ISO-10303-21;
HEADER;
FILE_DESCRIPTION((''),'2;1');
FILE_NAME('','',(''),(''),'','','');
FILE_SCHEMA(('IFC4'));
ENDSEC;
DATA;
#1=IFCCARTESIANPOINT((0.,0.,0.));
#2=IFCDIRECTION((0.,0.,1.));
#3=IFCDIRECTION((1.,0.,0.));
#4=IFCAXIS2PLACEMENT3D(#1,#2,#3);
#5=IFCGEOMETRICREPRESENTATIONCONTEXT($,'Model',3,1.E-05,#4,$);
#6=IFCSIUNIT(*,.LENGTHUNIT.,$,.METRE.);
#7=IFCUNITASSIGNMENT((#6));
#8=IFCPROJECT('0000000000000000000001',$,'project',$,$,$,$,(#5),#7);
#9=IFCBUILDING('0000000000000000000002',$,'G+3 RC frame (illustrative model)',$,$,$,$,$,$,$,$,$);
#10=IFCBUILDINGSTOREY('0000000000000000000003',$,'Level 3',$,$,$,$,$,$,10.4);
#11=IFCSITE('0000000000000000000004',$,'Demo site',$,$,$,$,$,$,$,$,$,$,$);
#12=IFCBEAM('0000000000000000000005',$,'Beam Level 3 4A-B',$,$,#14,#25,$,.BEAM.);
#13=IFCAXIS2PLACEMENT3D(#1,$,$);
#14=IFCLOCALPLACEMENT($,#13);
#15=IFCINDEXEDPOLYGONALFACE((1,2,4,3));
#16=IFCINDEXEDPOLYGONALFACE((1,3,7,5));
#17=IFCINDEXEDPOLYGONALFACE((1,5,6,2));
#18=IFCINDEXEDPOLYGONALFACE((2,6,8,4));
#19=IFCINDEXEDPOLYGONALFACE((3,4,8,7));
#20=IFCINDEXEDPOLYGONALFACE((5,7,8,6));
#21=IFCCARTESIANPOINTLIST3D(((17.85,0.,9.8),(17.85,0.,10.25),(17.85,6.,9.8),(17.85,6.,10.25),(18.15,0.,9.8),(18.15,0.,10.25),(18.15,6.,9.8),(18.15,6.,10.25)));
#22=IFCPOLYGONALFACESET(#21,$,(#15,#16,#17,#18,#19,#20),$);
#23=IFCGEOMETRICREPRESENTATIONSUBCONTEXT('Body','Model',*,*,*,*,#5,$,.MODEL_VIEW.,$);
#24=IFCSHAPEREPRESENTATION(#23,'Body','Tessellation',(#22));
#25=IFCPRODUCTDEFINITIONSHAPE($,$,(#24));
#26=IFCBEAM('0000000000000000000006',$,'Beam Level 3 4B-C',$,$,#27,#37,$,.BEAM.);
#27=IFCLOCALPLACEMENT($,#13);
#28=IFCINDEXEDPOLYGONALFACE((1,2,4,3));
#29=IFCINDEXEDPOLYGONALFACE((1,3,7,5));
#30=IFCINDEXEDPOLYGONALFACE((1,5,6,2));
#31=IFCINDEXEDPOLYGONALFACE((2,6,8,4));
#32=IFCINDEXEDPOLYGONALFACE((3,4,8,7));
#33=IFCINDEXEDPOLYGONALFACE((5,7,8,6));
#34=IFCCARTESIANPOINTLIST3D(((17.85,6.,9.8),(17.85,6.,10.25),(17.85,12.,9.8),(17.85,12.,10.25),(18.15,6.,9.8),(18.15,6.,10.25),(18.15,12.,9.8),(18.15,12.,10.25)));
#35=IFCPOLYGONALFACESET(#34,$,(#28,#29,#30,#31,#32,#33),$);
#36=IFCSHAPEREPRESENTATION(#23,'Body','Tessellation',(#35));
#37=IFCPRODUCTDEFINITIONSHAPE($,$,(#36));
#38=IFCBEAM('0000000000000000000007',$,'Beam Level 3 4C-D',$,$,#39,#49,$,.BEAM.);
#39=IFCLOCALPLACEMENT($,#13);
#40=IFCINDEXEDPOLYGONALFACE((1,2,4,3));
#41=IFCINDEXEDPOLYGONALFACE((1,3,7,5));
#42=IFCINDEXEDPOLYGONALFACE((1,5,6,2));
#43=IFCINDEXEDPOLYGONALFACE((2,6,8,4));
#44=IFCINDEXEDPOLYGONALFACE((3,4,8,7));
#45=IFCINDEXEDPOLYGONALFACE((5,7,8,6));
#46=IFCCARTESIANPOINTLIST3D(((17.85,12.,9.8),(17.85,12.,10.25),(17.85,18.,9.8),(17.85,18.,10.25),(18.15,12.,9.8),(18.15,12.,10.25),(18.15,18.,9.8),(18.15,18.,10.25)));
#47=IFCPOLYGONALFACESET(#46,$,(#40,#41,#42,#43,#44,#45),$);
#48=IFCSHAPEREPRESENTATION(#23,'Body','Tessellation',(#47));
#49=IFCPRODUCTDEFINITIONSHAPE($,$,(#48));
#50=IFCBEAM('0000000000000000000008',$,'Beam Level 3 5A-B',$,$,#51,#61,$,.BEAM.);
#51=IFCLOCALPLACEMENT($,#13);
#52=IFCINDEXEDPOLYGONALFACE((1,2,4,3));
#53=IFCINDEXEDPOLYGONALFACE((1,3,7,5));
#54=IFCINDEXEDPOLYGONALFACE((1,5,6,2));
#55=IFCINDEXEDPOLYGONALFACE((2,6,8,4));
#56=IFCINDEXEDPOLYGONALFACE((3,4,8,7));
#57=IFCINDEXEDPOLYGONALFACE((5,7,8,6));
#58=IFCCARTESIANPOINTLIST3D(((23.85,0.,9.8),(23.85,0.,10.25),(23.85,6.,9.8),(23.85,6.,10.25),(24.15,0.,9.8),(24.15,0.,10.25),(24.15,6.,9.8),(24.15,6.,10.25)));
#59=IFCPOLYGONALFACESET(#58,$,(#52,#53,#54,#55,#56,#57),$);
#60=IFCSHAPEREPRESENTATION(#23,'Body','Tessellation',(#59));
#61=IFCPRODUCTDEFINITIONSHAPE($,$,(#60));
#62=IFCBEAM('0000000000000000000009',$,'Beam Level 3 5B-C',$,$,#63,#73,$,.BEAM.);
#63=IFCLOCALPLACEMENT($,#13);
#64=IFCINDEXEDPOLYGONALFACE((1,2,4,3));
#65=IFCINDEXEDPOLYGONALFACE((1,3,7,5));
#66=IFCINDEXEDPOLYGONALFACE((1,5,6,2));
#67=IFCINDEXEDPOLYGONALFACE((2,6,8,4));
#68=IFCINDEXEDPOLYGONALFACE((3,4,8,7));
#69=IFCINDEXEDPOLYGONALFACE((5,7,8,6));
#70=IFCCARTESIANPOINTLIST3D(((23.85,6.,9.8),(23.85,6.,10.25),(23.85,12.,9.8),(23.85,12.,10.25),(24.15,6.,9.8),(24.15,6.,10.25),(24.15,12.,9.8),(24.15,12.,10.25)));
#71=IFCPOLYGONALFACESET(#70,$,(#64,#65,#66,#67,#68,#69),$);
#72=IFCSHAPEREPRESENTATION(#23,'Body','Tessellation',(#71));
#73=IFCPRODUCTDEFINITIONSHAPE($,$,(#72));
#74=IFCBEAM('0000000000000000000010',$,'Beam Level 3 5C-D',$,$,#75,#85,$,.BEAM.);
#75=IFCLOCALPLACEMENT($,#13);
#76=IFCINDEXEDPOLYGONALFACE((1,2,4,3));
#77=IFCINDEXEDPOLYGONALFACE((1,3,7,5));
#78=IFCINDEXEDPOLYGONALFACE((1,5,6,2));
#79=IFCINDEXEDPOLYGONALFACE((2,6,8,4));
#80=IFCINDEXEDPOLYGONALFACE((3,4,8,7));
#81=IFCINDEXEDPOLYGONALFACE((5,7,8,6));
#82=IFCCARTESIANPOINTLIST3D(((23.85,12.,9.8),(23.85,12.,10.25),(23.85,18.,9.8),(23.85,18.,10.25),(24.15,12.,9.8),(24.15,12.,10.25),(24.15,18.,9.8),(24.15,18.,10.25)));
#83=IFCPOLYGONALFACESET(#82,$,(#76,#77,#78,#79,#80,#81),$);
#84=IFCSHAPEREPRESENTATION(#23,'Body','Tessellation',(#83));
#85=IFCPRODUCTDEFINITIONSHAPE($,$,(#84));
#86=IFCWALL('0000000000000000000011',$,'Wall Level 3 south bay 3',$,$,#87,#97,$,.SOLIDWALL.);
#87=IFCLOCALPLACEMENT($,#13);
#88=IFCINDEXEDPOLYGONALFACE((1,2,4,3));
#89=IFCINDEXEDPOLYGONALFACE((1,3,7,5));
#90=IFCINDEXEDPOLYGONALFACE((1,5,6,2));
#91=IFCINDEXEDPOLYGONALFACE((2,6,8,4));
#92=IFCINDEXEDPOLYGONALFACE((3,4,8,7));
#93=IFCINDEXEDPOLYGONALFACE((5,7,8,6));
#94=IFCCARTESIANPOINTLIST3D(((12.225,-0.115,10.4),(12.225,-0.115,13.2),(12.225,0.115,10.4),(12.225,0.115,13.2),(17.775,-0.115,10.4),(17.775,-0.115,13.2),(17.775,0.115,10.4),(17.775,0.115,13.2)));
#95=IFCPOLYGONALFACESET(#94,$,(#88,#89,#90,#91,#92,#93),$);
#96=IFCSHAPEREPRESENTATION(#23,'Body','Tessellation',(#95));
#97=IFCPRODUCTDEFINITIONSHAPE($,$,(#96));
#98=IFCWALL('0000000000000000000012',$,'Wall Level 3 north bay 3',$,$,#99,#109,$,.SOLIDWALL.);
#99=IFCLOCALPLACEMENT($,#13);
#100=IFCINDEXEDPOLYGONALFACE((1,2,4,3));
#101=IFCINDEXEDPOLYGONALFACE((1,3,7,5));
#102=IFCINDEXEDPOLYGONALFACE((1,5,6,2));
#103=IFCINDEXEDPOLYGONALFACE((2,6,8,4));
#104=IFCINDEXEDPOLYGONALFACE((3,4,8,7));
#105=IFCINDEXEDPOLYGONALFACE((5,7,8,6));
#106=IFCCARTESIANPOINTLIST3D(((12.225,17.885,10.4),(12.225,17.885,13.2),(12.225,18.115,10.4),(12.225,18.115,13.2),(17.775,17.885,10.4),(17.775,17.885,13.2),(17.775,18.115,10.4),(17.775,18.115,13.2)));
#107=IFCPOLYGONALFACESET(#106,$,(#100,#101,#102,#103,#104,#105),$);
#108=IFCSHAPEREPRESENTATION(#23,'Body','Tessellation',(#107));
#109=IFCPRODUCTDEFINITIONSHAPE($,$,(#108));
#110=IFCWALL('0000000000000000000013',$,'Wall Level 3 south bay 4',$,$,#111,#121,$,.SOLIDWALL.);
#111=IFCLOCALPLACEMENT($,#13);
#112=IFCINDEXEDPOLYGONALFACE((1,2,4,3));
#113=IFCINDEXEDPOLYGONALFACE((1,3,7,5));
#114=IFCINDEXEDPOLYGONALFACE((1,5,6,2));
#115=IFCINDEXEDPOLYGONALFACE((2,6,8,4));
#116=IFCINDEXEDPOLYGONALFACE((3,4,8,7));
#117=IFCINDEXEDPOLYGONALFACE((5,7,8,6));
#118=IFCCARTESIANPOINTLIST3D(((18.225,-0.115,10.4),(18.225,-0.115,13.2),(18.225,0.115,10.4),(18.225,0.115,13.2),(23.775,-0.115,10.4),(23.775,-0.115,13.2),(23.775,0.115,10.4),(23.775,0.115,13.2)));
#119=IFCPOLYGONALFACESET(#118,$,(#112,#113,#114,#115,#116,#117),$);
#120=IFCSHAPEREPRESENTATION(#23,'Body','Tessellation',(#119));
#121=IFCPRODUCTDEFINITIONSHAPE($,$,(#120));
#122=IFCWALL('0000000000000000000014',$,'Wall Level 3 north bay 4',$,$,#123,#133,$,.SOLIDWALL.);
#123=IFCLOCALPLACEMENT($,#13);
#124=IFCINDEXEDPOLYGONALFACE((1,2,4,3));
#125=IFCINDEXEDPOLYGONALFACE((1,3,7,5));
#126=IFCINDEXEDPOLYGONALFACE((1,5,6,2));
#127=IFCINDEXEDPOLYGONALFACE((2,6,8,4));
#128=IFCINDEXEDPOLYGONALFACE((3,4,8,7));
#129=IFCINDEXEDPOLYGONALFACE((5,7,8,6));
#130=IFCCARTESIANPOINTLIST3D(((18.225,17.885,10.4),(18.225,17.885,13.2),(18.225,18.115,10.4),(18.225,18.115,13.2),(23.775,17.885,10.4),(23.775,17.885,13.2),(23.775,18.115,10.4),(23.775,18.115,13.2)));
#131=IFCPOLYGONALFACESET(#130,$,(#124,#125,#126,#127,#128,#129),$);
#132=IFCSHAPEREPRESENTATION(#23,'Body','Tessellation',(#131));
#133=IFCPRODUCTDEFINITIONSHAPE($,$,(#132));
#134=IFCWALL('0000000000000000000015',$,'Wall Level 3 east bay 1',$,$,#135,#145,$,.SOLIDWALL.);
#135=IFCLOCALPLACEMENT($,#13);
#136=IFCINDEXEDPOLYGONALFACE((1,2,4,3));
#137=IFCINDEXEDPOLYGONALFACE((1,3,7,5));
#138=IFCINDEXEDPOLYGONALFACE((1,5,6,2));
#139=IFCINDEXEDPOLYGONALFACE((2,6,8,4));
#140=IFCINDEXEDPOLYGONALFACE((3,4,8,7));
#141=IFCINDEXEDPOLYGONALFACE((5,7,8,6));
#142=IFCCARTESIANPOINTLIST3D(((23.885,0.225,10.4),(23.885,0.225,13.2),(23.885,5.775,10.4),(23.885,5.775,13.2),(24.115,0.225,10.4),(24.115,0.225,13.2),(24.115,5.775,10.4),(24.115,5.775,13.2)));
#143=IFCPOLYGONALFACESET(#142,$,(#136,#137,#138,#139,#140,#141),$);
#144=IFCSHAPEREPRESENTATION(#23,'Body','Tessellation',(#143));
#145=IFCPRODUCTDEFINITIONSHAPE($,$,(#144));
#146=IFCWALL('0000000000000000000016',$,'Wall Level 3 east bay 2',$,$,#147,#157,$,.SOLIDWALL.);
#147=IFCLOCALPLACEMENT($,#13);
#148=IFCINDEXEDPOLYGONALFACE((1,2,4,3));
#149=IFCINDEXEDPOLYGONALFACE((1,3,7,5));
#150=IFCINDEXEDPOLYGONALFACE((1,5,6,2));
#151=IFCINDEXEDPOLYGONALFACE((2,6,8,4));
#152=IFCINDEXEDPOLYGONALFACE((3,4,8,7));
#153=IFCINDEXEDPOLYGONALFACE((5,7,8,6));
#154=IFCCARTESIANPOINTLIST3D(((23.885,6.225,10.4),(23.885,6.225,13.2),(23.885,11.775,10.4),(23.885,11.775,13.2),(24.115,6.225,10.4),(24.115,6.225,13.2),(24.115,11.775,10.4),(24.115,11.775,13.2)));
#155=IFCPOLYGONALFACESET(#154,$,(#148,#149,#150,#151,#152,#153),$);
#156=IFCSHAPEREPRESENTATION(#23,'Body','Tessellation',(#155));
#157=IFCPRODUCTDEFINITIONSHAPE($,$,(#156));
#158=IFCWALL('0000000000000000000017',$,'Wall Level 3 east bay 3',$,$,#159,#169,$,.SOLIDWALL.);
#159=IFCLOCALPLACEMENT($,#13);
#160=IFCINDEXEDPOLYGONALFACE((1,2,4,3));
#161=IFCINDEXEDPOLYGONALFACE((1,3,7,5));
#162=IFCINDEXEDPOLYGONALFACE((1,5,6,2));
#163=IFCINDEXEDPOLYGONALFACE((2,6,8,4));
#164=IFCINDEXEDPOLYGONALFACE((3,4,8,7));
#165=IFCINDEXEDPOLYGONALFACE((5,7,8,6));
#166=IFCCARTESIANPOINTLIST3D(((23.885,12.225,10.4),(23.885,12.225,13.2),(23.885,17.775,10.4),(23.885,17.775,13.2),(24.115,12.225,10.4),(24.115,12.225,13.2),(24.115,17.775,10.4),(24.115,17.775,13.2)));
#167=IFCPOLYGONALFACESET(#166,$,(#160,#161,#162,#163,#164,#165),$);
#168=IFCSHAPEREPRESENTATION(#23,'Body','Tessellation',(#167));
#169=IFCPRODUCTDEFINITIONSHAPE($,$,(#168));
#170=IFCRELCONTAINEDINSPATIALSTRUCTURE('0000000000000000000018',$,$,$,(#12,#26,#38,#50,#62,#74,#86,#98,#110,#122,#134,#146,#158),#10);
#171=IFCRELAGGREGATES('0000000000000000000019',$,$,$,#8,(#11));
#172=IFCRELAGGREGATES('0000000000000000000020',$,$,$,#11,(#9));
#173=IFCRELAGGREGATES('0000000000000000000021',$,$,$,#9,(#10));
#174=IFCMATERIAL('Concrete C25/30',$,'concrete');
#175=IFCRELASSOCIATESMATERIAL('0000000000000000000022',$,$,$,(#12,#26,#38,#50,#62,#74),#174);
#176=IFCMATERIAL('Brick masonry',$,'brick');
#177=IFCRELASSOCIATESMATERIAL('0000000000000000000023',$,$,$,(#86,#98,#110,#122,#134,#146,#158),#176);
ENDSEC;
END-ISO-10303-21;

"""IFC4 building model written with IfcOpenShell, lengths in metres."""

from ifc_helpers import new_model, si_unit, frame, frame_2d, origin, origin_with_axes, place, context, subcontext, project, spatial, rectangle, extrude, material, element, save


model = new_model("IFC4")

# Units and contexts
model_context = context("Model", 3, precision=1e-05, world=origin_with_axes())
body_context = subcontext(model_context, "Body", "Model", "MODEL_VIEW")
ifc_project = project(units=[si_unit("LENGTHUNIT", "METRE")], contexts=[model_context])

# Site, building, storey
site = spatial("IfcSite", under=ifc_project, Name="Demo site")
building = spatial("IfcBuilding", under=site, Name="G+3 RC frame (illustrative model)")
storey = spatial("IfcBuildingStorey", under=building, Name="Level 3", Elevation=10.4)

# Shared definitions
ifc_material_1 = material(Name="Concrete C25/30", Category="concrete")

# Beams
for number, where, z_axis, x_axis, name in (
    (1, (17.85, 0.0, 9.8), (0.0, 0.0, 1.0), (1.0, 0.0, 0.0), "Beam Level 3 4A-B"),
    (2, (17.85, 6.0, 9.8), (0.0, 0.0, 1.0), (1.0, 0.0, 0.0), "Beam Level 3 4B-C"),
    (3, (17.85, 12.0, 9.8), (0.0, 0.0, 1.0), (1.0, 0.0, 0.0), "Beam Level 3 4C-D"),
    (4, (23.85, 0.0, 9.8), (0.0, 0.0, 1.0), (1.0, 0.0, 0.0), "Beam Level 3 5A-B"),
    (5, (23.85, 6.0, 9.8), (0.0, 0.0, 1.0), (1.0, 0.0, 0.0), "Beam Level 3 5B-C"),
    (6, (23.85, 12.0, 9.8), (0.0, 0.0, 1.0), (1.0, 0.0, 0.0), "Beam Level 3 5C-D"),
):
    element("IfcBeam", number, at=place(None, frame(where, z_axis=z_axis, x_axis=x_axis)), inside=storey, material=ifc_material_1, Name=name, PredefinedType="BEAM", context=body_context, shape_type="SweptSolid", body=[
        extrude(rectangle(XDim=0.3, YDim=6.0, at=frame_2d((0.15, 3.0))), origin(), (0.0, 0.0, 1.0), 0.45),
    ])

# Walls
ifc_material_2 = material(Name="Brick masonry", Category="brick")
for number, where, z_axis, x_axis, name in (
    (7, (12.225, -0.115, 10.4), (0.0, 0.0, 1.0), (1.0, 0.0, 0.0), "Wall Level 3 south bay 3"),
    (8, (12.225, 17.885, 10.4), (0.0, 0.0, 1.0), (1.0, 0.0, 0.0), "Wall Level 3 north bay 3"),
    (9, (18.225, -0.115, 10.4), (0.0, 0.0, 1.0), (1.0, 0.0, 0.0), "Wall Level 3 south bay 4"),
    (10, (18.225, 17.885, 10.4), (0.0, 0.0, 1.0), (1.0, 0.0, 0.0), "Wall Level 3 north bay 4"),
):
    element("IfcWall", number, at=place(None, frame(where, z_axis=z_axis, x_axis=x_axis)), inside=storey, material=ifc_material_2, Name=name, PredefinedType="SOLIDWALL", context=body_context, shape_type="SweptSolid", body=[
        extrude(rectangle(XDim=5.55, YDim=0.23, at=frame_2d((2.775, 0.115))), origin(), (0.0, 0.0, 1.0), 2.8),
    ])
for number, where, z_axis, x_axis, name in (
    (11, (23.885, 0.225, 10.4), (0.0, 0.0, 1.0), (1.0, 0.0, 0.0), "Wall Level 3 east bay 1"),
    (12, (23.885, 6.225, 10.4), (0.0, 0.0, 1.0), (1.0, 0.0, 0.0), "Wall Level 3 east bay 2"),
    (13, (23.885, 12.225, 10.4), (0.0, 0.0, 1.0), (1.0, 0.0, 0.0), "Wall Level 3 east bay 3"),
):
    element("IfcWall", number, at=place(None, frame(where, z_axis=z_axis, x_axis=x_axis)), inside=storey, material=ifc_material_2, Name=name, PredefinedType="SOLIDWALL", context=body_context, shape_type="SweptSolid", body=[
        extrude(rectangle(XDim=0.23, YDim=5.55, at=frame_2d((0.115, 2.775))), origin(), (0.0, 0.0, 1.0), 2.8),
    ])

save(model, "model.ifc")
